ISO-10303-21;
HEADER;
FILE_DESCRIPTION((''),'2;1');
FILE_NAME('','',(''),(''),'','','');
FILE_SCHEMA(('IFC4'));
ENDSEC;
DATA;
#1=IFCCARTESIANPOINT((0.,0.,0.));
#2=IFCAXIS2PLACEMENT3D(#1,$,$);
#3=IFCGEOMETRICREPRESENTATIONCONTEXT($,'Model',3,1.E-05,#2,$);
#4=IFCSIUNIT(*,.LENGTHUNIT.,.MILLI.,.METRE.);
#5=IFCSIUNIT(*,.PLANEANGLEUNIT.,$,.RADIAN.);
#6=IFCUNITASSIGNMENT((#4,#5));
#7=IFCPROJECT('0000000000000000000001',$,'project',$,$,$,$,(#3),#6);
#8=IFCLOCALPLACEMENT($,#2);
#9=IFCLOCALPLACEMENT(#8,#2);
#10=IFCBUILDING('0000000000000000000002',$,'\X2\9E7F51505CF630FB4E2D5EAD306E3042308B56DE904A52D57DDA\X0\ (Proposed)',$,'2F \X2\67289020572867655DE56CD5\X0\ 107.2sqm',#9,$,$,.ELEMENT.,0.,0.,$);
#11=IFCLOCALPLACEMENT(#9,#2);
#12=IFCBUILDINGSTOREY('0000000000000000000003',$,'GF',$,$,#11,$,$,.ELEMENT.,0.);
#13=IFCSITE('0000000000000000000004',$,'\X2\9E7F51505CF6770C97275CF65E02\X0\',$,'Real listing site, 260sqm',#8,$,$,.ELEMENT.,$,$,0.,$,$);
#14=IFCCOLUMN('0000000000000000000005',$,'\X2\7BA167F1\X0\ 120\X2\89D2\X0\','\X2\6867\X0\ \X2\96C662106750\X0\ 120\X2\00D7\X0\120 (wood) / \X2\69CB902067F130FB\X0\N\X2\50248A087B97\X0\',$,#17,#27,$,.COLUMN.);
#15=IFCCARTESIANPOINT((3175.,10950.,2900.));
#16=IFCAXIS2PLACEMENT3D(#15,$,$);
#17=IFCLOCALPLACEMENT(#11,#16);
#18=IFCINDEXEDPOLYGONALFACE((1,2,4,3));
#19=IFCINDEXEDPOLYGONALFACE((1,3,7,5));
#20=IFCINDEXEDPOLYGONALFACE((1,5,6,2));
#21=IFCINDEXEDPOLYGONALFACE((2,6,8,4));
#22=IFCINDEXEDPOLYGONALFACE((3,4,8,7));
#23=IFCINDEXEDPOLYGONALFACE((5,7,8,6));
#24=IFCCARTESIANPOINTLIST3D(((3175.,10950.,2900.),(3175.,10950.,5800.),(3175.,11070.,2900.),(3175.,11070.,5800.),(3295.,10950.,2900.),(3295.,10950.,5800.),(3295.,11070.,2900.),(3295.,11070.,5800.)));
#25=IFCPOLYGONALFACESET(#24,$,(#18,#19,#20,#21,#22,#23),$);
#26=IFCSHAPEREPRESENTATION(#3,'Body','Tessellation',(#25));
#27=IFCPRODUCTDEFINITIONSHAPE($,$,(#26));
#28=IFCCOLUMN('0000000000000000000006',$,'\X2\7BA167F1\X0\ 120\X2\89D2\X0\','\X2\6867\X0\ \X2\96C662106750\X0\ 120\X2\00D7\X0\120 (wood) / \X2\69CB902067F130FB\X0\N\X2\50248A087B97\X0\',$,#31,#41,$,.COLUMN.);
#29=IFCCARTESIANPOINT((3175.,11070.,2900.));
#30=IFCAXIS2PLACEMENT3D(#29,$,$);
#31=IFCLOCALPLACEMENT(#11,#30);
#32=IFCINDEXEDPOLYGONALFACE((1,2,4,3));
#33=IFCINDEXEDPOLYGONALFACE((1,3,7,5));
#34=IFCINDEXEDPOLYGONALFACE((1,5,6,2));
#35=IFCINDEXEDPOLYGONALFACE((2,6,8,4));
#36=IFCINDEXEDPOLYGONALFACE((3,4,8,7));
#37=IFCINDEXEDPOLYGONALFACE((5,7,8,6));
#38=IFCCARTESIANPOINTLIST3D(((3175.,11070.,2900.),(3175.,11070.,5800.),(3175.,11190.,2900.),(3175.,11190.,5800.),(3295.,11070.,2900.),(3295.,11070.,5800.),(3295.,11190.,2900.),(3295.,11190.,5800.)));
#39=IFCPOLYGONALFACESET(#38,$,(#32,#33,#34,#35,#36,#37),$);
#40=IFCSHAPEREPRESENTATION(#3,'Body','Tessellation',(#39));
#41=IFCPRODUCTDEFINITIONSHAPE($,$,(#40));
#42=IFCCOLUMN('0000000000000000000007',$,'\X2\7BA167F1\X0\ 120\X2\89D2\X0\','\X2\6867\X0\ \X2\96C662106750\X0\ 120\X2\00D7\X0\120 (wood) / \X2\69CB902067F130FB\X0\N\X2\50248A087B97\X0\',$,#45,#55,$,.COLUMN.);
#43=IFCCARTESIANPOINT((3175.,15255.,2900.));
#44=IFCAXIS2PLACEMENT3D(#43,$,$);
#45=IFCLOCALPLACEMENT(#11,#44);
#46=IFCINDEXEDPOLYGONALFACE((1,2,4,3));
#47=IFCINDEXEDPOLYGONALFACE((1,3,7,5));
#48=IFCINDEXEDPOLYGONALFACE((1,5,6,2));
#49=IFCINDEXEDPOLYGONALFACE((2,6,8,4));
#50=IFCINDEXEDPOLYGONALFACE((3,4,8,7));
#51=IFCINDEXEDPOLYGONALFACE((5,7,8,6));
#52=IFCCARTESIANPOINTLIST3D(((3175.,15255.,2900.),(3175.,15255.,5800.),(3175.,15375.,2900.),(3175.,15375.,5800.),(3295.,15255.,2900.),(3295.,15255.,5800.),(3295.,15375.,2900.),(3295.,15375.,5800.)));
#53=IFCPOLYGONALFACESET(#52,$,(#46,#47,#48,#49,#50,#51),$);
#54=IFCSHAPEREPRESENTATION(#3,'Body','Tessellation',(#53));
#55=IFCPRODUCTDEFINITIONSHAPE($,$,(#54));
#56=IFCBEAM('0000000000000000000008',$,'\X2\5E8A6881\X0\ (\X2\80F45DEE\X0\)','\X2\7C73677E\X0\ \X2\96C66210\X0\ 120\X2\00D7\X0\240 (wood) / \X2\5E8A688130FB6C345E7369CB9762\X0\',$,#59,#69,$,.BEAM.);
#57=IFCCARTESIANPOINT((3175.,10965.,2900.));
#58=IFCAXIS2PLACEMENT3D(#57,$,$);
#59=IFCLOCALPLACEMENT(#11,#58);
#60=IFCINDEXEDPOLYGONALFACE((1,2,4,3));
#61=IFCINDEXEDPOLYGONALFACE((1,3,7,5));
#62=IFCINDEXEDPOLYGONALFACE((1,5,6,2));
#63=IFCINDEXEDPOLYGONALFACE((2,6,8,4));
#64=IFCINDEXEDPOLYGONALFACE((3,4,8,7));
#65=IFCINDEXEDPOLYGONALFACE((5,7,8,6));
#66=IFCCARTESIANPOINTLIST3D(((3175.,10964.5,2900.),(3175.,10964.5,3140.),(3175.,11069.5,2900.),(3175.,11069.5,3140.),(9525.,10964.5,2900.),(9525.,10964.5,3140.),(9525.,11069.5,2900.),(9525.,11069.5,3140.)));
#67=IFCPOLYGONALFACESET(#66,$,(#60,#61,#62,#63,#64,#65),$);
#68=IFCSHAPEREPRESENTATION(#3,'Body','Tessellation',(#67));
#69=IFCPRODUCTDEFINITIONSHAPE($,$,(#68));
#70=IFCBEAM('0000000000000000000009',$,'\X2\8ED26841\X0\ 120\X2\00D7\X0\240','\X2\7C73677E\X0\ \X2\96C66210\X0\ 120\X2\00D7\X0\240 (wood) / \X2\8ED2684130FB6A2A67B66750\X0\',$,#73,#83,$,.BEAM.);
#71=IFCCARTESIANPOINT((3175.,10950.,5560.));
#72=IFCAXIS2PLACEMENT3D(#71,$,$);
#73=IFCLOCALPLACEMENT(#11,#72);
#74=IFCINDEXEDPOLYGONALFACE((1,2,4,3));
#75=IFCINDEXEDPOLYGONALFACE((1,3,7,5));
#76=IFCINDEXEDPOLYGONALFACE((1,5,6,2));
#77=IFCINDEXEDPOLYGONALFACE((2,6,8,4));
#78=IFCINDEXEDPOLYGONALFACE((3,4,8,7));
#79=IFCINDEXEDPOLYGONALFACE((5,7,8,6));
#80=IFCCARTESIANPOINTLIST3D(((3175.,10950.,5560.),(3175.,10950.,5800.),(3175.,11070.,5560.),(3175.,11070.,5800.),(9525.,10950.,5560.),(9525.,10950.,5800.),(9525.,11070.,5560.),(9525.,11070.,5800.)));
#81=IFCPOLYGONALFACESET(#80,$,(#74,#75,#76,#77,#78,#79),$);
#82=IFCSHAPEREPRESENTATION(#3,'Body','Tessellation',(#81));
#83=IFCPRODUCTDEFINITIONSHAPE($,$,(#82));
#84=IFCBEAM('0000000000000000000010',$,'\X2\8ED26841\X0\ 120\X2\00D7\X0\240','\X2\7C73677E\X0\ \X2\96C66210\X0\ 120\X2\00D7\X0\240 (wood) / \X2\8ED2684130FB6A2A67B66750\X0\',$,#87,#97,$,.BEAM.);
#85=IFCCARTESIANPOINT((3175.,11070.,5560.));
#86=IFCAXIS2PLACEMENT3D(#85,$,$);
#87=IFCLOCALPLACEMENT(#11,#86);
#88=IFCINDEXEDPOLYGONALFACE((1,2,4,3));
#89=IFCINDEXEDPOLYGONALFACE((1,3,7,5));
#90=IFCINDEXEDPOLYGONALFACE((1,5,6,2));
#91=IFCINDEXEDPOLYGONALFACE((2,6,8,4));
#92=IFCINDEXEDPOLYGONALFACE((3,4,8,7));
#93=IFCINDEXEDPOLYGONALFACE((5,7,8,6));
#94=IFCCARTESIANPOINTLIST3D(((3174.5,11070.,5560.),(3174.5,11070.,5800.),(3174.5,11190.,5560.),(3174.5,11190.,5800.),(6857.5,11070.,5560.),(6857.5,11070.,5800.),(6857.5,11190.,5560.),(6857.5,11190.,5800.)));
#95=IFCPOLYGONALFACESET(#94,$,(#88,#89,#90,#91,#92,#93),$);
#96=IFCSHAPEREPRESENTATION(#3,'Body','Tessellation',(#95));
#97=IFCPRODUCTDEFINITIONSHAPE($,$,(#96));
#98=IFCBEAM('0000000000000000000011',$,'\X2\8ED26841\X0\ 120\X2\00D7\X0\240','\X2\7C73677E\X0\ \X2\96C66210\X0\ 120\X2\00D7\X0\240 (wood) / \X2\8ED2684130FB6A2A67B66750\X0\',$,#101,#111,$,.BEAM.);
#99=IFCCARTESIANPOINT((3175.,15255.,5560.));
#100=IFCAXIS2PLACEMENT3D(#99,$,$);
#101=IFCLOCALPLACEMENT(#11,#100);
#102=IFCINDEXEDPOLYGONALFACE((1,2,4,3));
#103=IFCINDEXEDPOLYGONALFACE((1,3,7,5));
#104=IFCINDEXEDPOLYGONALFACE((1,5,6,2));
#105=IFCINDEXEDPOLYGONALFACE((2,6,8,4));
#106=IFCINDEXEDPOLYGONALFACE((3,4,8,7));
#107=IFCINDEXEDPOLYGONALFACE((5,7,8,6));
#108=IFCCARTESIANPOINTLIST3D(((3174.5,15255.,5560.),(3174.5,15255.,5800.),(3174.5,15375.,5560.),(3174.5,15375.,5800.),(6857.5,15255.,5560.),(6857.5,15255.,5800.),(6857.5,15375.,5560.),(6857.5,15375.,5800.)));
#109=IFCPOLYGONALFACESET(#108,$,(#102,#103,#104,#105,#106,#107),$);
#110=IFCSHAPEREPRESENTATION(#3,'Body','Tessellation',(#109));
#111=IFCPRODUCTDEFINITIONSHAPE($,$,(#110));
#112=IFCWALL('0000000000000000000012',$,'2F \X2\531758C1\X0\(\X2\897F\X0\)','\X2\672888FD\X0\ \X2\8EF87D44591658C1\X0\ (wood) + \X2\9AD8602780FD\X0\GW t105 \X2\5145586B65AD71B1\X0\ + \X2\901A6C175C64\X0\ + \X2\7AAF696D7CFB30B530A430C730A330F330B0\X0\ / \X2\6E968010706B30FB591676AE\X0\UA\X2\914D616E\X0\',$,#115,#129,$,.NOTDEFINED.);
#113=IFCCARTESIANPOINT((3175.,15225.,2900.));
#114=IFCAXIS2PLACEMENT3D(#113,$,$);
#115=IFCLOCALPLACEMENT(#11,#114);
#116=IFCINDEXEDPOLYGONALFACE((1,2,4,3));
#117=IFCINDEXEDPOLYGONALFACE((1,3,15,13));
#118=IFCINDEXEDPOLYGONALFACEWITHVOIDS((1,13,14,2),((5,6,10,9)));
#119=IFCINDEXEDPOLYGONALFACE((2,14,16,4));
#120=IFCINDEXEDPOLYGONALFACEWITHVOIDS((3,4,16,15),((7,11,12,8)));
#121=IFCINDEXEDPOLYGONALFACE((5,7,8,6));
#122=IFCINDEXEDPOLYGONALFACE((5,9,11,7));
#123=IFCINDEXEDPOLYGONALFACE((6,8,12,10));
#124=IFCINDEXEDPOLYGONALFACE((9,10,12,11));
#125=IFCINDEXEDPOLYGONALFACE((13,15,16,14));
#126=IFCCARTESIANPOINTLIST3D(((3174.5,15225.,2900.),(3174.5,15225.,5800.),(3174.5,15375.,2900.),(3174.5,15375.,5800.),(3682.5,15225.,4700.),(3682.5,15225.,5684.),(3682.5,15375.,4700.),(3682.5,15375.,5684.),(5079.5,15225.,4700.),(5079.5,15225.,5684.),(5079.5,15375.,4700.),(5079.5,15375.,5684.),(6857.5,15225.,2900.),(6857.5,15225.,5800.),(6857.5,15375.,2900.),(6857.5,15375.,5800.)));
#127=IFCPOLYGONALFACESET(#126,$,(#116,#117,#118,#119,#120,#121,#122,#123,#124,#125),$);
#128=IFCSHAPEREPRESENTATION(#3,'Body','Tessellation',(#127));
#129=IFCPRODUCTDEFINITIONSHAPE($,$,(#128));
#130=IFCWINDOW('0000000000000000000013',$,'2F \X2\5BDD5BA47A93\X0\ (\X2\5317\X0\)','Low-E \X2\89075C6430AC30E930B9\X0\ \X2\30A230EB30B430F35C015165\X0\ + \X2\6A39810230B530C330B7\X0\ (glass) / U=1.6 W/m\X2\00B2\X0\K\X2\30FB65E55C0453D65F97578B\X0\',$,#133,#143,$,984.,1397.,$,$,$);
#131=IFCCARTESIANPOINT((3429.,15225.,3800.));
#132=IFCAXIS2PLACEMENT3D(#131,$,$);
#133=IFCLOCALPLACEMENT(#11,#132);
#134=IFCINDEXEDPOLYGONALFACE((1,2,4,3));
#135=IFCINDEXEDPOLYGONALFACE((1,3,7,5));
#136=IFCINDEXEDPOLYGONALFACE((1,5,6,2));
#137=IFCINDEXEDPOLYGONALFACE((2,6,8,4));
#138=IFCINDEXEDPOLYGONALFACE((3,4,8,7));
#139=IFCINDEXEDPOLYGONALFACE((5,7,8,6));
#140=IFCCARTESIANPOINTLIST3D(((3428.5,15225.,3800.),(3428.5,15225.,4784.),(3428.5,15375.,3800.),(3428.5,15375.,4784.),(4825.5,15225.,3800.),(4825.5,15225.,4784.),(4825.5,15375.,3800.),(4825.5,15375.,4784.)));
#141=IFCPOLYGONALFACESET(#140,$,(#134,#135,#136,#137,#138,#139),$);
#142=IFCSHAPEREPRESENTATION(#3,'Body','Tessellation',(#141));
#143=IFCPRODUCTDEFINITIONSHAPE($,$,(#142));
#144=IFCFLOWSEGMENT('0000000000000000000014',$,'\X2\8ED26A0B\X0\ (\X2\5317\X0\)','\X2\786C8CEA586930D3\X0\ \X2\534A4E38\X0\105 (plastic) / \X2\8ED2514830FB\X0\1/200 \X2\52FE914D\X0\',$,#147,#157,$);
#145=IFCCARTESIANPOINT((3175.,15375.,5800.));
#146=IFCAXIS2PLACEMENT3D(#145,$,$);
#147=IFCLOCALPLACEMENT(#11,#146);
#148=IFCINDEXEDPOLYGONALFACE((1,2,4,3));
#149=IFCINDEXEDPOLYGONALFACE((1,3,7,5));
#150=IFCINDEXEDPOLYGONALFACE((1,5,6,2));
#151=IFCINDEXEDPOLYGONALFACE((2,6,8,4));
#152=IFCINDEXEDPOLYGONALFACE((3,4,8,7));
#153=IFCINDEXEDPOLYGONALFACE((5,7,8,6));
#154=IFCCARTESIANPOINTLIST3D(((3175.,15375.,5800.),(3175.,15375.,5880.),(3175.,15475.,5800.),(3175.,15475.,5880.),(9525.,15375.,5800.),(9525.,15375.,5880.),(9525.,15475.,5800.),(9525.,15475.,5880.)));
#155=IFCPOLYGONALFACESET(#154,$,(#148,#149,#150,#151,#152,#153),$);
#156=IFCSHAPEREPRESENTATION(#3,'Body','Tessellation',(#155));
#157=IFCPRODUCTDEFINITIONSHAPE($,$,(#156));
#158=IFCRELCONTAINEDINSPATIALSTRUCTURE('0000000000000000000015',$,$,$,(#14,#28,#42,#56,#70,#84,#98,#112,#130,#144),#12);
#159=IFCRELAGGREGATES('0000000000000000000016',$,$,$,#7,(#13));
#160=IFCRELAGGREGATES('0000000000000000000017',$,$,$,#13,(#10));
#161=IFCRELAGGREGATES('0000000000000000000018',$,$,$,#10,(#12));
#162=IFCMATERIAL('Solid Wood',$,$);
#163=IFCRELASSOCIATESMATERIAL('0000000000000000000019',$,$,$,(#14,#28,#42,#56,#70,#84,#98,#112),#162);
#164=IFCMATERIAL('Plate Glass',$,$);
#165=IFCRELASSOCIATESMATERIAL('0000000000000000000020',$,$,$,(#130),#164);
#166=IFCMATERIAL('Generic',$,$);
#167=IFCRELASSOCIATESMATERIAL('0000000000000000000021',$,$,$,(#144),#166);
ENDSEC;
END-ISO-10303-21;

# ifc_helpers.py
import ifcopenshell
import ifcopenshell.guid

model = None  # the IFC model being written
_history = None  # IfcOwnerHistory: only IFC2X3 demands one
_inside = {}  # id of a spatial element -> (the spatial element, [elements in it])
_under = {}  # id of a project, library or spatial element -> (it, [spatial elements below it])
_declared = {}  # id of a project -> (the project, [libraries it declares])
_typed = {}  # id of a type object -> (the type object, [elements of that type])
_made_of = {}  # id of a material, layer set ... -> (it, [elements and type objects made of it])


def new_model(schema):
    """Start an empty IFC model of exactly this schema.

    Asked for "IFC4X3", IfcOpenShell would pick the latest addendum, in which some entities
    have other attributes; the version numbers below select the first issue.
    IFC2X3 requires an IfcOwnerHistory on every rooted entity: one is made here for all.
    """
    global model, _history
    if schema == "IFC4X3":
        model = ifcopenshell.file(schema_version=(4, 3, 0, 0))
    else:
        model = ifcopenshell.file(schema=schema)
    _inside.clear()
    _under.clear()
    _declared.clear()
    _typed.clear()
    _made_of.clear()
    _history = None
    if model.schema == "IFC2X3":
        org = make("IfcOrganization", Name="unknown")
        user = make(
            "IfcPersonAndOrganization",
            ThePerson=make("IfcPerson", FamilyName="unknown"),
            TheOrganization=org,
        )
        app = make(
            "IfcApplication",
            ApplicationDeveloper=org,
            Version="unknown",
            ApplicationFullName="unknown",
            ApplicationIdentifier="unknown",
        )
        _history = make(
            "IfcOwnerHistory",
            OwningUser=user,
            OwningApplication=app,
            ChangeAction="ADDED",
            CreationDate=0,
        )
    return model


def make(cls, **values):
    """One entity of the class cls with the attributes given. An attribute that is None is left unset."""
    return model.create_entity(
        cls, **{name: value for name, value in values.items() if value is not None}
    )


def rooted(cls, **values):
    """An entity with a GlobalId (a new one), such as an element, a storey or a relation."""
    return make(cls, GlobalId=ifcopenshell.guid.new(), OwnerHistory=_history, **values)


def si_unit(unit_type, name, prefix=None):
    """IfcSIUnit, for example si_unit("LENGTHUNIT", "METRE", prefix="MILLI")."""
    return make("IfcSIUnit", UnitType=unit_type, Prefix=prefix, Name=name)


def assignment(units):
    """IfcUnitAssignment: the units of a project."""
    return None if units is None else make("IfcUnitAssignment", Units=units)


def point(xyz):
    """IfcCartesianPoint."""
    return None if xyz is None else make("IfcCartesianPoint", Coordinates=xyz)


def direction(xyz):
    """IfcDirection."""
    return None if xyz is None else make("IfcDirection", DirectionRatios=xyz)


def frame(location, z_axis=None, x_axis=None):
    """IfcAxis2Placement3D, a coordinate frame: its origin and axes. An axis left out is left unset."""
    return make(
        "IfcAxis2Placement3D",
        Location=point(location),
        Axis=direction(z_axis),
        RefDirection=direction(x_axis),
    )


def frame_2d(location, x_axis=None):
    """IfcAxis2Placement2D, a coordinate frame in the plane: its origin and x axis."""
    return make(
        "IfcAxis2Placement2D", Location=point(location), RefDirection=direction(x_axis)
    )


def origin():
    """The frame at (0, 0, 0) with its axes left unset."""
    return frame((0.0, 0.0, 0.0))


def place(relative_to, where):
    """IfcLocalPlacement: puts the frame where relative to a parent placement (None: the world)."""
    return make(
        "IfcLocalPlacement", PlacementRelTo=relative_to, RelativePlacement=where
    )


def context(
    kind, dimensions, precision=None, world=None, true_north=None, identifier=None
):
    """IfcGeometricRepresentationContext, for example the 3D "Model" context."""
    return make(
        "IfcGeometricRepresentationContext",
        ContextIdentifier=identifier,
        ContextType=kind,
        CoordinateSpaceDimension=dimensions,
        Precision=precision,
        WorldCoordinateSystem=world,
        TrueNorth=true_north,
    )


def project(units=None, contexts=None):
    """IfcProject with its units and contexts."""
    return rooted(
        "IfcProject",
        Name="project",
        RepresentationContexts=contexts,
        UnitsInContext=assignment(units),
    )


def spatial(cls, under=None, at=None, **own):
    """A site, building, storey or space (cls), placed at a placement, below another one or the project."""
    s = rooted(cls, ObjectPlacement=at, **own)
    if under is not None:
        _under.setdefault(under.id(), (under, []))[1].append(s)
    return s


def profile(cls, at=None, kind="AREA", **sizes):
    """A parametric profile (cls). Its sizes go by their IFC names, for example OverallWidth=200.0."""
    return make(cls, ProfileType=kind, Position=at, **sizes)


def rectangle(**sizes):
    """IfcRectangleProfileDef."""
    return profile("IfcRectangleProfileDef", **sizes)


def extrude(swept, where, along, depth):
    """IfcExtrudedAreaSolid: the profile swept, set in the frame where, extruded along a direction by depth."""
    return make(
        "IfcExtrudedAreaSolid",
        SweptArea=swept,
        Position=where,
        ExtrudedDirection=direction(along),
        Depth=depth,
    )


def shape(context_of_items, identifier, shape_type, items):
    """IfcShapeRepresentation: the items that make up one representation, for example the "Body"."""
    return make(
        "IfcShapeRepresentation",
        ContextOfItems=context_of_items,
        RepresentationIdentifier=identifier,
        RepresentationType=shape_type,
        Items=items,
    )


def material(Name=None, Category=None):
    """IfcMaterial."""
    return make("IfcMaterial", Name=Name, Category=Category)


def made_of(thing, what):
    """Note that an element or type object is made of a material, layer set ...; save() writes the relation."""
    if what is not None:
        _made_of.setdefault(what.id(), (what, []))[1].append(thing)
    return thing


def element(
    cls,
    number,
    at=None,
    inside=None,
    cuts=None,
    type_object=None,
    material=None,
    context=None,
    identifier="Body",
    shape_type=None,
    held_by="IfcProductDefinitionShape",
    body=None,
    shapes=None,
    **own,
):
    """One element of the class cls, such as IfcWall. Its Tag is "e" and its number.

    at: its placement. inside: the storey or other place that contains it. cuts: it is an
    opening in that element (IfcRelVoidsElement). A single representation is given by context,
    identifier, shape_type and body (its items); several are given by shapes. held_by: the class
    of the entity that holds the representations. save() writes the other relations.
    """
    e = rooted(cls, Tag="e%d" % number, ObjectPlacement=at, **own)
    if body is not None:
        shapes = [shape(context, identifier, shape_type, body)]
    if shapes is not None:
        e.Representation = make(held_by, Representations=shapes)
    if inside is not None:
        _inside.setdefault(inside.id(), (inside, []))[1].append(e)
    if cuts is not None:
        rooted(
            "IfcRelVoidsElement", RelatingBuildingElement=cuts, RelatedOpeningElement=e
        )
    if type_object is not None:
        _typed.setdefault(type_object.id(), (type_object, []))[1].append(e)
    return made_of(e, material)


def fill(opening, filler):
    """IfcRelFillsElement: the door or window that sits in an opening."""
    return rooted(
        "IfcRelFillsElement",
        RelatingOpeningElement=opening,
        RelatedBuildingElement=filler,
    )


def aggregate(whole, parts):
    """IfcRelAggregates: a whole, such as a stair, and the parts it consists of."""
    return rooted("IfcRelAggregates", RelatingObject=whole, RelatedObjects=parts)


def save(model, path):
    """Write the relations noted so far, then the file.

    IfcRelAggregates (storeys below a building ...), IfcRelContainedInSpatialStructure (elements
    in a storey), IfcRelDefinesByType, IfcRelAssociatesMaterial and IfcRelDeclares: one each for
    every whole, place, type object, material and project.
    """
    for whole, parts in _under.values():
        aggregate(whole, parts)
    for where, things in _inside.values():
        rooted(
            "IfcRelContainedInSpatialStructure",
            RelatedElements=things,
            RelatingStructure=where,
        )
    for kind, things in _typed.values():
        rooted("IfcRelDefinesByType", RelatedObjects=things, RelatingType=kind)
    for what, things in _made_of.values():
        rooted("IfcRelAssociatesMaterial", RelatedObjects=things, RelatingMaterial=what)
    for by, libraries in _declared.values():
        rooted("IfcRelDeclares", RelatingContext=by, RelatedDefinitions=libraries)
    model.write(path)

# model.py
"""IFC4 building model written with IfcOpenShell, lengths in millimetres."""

from ifc_helpers import new_model, si_unit, frame, frame_2d, origin, place, context, project, spatial, rectangle, extrude, material, element, fill, save


model = new_model("IFC4")

# Units and contexts
model_context = context("Model", 3, precision=1e-05, world=origin())
ifc_project = project(units=[si_unit("LENGTHUNIT", "METRE", prefix="MILLI"), si_unit("PLANEANGLEUNIT", "RADIAN")], contexts=[model_context])

# Site, building, storey
site_placement = place(None, origin())
site = spatial("IfcSite", under=ifc_project, at=site_placement, Name="鹿児島県霧島市", ObjectType="Real listing site, 260sqm", CompositionType="ELEMENT", RefElevation=0.0)
building_placement = place(site_placement, origin())
building = spatial("IfcBuilding", under=site, at=building_placement, Name="鹿児島・中庭のある回遊動線 (Proposed)", ObjectType="2F 木造在来工法 107.2sqm", CompositionType="ELEMENT", ElevationOfRefHeight=0.0, ElevationOfTerrain=0.0)
storey_placement = place(building_placement, origin())
storey = spatial("IfcBuildingStorey", under=building, at=storey_placement, Name="GF", CompositionType="ELEMENT", Elevation=0.0)

# Columns
ifc_material_1 = material(Name="Solid Wood")
column_1_placement = place(storey_placement, frame((3175.0, 10950.0, 2900.0)))
element("IfcColumn", 1, at=column_1_placement, inside=storey, material=ifc_material_1, Name="管柱 120角", Description="桧 集成材 120×120 (wood) / 構造柱・N値計算", PredefinedType="COLUMN", context=model_context, shape_type="SweptSolid", body=[
    extrude(rectangle(XDim=120.0, YDim=120.0, at=frame_2d((60.0, 60.0))), frame((3175.0, 10950.0, 2900.0)), (0.0, 0.0, 1.0), 2900.0),
])
column_2_placement = place(storey_placement, frame((3175.0, 11070.0, 2900.0)))
element("IfcColumn", 2, at=column_2_placement, inside=storey, material=ifc_material_1, Name="管柱 120角", Description="桧 集成材 120×120 (wood) / 構造柱・N値計算", PredefinedType="COLUMN", context=model_context, shape_type="SweptSolid", body=[
    extrude(rectangle(XDim=120.0, YDim=120.0, at=frame_2d((60.0, 60.0))), frame((3175.0, 11070.0, 2900.0)), (0.0, 0.0, 1.0), 2900.0),
])
column_3_placement = place(storey_placement, frame((3175.0, 15255.0, 2900.0)))
element("IfcColumn", 3, at=column_3_placement, inside=storey, material=ifc_material_1, Name="管柱 120角", Description="桧 集成材 120×120 (wood) / 構造柱・N値計算", PredefinedType="COLUMN", context=model_context, shape_type="SweptSolid", body=[
    extrude(rectangle(XDim=120.0, YDim=120.0, at=frame_2d((60.0, 60.0))), frame((3175.0, 15255.0, 2900.0)), (0.0, 0.0, 1.0), 2900.0),
])

# Beams
beam_1_placement = place(storey_placement, frame((3175.0, 10965.0, 2900.0)))
element("IfcBeam", 4, at=beam_1_placement, inside=storey, material=ifc_material_1, Name="床梁 (胴差)", Description="米松 集成 120×240 (wood) / 床梁・水平構面", PredefinedType="BEAM", context=model_context, shape_type="SweptSolid", body=[
    extrude(rectangle(XDim=6350.0, YDim=105.0, at=frame_2d((3175.0, 52.0))), frame((3175.0, 10965.0, 2900.0)), (0.0, 0.0, 1.0), 240.0),
])
beam_2_placement = place(storey_placement, frame((3175.0, 10950.0, 5560.0)))
element("IfcBeam", 5, at=beam_2_placement, inside=storey, material=ifc_material_1, Name="軒桁 120×240", Description="米松 集成 120×240 (wood) / 軒桁・横架材", PredefinedType="BEAM", context=model_context, shape_type="SweptSolid", body=[
    extrude(rectangle(XDim=6350.0, YDim=120.0, at=frame_2d((3175.0, 60.0))), frame((3175.0, 10950.0, 5560.0)), (0.0, 0.0, 1.0), 240.0),
])
beam_3_placement = place(storey_placement, frame((3175.0, 11070.0, 5560.0)))
element("IfcBeam", 6, at=beam_3_placement, inside=storey, material=ifc_material_1, Name="軒桁 120×240", Description="米松 集成 120×240 (wood) / 軒桁・横架材", PredefinedType="BEAM", context=model_context, shape_type="SweptSolid", body=[
    extrude(rectangle(XDim=3683.0, YDim=120.0, at=frame_2d((1841.0, 60.0))), frame((3175.0, 11070.0, 5560.0)), (0.0, 0.0, 1.0), 240.0),
])
beam_4_placement = place(storey_placement, frame((3175.0, 15255.0, 5560.0)))
element("IfcBeam", 7, at=beam_4_placement, inside=storey, material=ifc_material_1, Name="軒桁 120×240", Description="米松 集成 120×240 (wood) / 軒桁・横架材", PredefinedType="BEAM", context=model_context, shape_type="SweptSolid", body=[
    extrude(rectangle(XDim=3683.0, YDim=120.0, at=frame_2d((1841.0, 60.0))), frame((3175.0, 15255.0, 5560.0)), (0.0, 0.0, 1.0), 240.0),
])

# Wall, opening, window
wall_1_placement = place(storey_placement, frame((3175.0, 15225.0, 2900.0)))
wall_1 = element("IfcWall", 8, at=wall_1_placement, inside=storey, material=ifc_material_1, Name="2F 北壁(西)", Description="木製 軸組外壁 (wood) + 高性能GW t105 充填断熱 + 通気層 + 窯業系サイディング / 準耐火・外皮UA配慮", PredefinedType="NOTDEFINED", context=model_context, shape_type="SweptSolid", body=[
    extrude(rectangle(XDim=3683.0, YDim=150.0, at=frame_2d((1841.0, 75.0))), frame((3175.0, 15225.0, 2900.0)), (0.0, 0.0, 1.0), 2900.0),
])
opening_placement = place(storey_placement, frame((3429.0, 15225.0, 3800.0)))
opening = element("IfcOpeningElement", 9, at=opening_placement, cuts=wall_1, PredefinedType="NOTDEFINED", context=model_context, shape_type="SweptSolid", body=[
    extrude(rectangle(XDim=1397.0, YDim=150.0, at=frame_2d((698.0, 75.0))), frame((3429.0, 15225.0, 3800.0)), (0.0, 0.0, 1.0), 984.0),
])
ifc_material_2 = material(Name="Plate Glass")
window_placement = place(storey_placement, frame((3429.0, 15225.0, 3800.0)))
window = element("IfcWindow", 10, at=window_placement, inside=storey, material=ifc_material_2, Name="2F 寝室窓 (北)", Description="Low-E 複層ガラス アルゴン封入 + 樹脂サッシ (glass) / U=1.6 W/m²K・日射取得型", OverallHeight=984.0, OverallWidth=1397.0, context=model_context, shape_type="SweptSolid", body=[
    extrude(rectangle(XDim=1397.0, YDim=150.0, at=frame_2d((698.0, 75.0))), frame((3429.0, 15225.0, 3800.0)), (0.0, 0.0, 1.0), 984.0),
])
fill(opening, window)

# Shared definitions
ifc_material_3 = material(Name="Generic")

# Flow segment
flow_segment_placement = place(storey_placement, frame((3175.0, 15375.0, 5800.0)))
element("IfcFlowSegment", 11, at=flow_segment_placement, inside=storey, material=ifc_material_3, Name="軒樋 (北)", Description="硬質塩ビ 半丸105 (plastic) / 軒先・1/200 勾配", context=model_context, shape_type="SweptSolid", body=[
    extrude(rectangle(XDim=6350.0, YDim=100.0, at=frame_2d((3175.0, 50.0))), frame((3175.0, 15375.0, 5800.0)), (0.0, 0.0, 1.0), 80.0),
])

save(model, "model.ifc")
